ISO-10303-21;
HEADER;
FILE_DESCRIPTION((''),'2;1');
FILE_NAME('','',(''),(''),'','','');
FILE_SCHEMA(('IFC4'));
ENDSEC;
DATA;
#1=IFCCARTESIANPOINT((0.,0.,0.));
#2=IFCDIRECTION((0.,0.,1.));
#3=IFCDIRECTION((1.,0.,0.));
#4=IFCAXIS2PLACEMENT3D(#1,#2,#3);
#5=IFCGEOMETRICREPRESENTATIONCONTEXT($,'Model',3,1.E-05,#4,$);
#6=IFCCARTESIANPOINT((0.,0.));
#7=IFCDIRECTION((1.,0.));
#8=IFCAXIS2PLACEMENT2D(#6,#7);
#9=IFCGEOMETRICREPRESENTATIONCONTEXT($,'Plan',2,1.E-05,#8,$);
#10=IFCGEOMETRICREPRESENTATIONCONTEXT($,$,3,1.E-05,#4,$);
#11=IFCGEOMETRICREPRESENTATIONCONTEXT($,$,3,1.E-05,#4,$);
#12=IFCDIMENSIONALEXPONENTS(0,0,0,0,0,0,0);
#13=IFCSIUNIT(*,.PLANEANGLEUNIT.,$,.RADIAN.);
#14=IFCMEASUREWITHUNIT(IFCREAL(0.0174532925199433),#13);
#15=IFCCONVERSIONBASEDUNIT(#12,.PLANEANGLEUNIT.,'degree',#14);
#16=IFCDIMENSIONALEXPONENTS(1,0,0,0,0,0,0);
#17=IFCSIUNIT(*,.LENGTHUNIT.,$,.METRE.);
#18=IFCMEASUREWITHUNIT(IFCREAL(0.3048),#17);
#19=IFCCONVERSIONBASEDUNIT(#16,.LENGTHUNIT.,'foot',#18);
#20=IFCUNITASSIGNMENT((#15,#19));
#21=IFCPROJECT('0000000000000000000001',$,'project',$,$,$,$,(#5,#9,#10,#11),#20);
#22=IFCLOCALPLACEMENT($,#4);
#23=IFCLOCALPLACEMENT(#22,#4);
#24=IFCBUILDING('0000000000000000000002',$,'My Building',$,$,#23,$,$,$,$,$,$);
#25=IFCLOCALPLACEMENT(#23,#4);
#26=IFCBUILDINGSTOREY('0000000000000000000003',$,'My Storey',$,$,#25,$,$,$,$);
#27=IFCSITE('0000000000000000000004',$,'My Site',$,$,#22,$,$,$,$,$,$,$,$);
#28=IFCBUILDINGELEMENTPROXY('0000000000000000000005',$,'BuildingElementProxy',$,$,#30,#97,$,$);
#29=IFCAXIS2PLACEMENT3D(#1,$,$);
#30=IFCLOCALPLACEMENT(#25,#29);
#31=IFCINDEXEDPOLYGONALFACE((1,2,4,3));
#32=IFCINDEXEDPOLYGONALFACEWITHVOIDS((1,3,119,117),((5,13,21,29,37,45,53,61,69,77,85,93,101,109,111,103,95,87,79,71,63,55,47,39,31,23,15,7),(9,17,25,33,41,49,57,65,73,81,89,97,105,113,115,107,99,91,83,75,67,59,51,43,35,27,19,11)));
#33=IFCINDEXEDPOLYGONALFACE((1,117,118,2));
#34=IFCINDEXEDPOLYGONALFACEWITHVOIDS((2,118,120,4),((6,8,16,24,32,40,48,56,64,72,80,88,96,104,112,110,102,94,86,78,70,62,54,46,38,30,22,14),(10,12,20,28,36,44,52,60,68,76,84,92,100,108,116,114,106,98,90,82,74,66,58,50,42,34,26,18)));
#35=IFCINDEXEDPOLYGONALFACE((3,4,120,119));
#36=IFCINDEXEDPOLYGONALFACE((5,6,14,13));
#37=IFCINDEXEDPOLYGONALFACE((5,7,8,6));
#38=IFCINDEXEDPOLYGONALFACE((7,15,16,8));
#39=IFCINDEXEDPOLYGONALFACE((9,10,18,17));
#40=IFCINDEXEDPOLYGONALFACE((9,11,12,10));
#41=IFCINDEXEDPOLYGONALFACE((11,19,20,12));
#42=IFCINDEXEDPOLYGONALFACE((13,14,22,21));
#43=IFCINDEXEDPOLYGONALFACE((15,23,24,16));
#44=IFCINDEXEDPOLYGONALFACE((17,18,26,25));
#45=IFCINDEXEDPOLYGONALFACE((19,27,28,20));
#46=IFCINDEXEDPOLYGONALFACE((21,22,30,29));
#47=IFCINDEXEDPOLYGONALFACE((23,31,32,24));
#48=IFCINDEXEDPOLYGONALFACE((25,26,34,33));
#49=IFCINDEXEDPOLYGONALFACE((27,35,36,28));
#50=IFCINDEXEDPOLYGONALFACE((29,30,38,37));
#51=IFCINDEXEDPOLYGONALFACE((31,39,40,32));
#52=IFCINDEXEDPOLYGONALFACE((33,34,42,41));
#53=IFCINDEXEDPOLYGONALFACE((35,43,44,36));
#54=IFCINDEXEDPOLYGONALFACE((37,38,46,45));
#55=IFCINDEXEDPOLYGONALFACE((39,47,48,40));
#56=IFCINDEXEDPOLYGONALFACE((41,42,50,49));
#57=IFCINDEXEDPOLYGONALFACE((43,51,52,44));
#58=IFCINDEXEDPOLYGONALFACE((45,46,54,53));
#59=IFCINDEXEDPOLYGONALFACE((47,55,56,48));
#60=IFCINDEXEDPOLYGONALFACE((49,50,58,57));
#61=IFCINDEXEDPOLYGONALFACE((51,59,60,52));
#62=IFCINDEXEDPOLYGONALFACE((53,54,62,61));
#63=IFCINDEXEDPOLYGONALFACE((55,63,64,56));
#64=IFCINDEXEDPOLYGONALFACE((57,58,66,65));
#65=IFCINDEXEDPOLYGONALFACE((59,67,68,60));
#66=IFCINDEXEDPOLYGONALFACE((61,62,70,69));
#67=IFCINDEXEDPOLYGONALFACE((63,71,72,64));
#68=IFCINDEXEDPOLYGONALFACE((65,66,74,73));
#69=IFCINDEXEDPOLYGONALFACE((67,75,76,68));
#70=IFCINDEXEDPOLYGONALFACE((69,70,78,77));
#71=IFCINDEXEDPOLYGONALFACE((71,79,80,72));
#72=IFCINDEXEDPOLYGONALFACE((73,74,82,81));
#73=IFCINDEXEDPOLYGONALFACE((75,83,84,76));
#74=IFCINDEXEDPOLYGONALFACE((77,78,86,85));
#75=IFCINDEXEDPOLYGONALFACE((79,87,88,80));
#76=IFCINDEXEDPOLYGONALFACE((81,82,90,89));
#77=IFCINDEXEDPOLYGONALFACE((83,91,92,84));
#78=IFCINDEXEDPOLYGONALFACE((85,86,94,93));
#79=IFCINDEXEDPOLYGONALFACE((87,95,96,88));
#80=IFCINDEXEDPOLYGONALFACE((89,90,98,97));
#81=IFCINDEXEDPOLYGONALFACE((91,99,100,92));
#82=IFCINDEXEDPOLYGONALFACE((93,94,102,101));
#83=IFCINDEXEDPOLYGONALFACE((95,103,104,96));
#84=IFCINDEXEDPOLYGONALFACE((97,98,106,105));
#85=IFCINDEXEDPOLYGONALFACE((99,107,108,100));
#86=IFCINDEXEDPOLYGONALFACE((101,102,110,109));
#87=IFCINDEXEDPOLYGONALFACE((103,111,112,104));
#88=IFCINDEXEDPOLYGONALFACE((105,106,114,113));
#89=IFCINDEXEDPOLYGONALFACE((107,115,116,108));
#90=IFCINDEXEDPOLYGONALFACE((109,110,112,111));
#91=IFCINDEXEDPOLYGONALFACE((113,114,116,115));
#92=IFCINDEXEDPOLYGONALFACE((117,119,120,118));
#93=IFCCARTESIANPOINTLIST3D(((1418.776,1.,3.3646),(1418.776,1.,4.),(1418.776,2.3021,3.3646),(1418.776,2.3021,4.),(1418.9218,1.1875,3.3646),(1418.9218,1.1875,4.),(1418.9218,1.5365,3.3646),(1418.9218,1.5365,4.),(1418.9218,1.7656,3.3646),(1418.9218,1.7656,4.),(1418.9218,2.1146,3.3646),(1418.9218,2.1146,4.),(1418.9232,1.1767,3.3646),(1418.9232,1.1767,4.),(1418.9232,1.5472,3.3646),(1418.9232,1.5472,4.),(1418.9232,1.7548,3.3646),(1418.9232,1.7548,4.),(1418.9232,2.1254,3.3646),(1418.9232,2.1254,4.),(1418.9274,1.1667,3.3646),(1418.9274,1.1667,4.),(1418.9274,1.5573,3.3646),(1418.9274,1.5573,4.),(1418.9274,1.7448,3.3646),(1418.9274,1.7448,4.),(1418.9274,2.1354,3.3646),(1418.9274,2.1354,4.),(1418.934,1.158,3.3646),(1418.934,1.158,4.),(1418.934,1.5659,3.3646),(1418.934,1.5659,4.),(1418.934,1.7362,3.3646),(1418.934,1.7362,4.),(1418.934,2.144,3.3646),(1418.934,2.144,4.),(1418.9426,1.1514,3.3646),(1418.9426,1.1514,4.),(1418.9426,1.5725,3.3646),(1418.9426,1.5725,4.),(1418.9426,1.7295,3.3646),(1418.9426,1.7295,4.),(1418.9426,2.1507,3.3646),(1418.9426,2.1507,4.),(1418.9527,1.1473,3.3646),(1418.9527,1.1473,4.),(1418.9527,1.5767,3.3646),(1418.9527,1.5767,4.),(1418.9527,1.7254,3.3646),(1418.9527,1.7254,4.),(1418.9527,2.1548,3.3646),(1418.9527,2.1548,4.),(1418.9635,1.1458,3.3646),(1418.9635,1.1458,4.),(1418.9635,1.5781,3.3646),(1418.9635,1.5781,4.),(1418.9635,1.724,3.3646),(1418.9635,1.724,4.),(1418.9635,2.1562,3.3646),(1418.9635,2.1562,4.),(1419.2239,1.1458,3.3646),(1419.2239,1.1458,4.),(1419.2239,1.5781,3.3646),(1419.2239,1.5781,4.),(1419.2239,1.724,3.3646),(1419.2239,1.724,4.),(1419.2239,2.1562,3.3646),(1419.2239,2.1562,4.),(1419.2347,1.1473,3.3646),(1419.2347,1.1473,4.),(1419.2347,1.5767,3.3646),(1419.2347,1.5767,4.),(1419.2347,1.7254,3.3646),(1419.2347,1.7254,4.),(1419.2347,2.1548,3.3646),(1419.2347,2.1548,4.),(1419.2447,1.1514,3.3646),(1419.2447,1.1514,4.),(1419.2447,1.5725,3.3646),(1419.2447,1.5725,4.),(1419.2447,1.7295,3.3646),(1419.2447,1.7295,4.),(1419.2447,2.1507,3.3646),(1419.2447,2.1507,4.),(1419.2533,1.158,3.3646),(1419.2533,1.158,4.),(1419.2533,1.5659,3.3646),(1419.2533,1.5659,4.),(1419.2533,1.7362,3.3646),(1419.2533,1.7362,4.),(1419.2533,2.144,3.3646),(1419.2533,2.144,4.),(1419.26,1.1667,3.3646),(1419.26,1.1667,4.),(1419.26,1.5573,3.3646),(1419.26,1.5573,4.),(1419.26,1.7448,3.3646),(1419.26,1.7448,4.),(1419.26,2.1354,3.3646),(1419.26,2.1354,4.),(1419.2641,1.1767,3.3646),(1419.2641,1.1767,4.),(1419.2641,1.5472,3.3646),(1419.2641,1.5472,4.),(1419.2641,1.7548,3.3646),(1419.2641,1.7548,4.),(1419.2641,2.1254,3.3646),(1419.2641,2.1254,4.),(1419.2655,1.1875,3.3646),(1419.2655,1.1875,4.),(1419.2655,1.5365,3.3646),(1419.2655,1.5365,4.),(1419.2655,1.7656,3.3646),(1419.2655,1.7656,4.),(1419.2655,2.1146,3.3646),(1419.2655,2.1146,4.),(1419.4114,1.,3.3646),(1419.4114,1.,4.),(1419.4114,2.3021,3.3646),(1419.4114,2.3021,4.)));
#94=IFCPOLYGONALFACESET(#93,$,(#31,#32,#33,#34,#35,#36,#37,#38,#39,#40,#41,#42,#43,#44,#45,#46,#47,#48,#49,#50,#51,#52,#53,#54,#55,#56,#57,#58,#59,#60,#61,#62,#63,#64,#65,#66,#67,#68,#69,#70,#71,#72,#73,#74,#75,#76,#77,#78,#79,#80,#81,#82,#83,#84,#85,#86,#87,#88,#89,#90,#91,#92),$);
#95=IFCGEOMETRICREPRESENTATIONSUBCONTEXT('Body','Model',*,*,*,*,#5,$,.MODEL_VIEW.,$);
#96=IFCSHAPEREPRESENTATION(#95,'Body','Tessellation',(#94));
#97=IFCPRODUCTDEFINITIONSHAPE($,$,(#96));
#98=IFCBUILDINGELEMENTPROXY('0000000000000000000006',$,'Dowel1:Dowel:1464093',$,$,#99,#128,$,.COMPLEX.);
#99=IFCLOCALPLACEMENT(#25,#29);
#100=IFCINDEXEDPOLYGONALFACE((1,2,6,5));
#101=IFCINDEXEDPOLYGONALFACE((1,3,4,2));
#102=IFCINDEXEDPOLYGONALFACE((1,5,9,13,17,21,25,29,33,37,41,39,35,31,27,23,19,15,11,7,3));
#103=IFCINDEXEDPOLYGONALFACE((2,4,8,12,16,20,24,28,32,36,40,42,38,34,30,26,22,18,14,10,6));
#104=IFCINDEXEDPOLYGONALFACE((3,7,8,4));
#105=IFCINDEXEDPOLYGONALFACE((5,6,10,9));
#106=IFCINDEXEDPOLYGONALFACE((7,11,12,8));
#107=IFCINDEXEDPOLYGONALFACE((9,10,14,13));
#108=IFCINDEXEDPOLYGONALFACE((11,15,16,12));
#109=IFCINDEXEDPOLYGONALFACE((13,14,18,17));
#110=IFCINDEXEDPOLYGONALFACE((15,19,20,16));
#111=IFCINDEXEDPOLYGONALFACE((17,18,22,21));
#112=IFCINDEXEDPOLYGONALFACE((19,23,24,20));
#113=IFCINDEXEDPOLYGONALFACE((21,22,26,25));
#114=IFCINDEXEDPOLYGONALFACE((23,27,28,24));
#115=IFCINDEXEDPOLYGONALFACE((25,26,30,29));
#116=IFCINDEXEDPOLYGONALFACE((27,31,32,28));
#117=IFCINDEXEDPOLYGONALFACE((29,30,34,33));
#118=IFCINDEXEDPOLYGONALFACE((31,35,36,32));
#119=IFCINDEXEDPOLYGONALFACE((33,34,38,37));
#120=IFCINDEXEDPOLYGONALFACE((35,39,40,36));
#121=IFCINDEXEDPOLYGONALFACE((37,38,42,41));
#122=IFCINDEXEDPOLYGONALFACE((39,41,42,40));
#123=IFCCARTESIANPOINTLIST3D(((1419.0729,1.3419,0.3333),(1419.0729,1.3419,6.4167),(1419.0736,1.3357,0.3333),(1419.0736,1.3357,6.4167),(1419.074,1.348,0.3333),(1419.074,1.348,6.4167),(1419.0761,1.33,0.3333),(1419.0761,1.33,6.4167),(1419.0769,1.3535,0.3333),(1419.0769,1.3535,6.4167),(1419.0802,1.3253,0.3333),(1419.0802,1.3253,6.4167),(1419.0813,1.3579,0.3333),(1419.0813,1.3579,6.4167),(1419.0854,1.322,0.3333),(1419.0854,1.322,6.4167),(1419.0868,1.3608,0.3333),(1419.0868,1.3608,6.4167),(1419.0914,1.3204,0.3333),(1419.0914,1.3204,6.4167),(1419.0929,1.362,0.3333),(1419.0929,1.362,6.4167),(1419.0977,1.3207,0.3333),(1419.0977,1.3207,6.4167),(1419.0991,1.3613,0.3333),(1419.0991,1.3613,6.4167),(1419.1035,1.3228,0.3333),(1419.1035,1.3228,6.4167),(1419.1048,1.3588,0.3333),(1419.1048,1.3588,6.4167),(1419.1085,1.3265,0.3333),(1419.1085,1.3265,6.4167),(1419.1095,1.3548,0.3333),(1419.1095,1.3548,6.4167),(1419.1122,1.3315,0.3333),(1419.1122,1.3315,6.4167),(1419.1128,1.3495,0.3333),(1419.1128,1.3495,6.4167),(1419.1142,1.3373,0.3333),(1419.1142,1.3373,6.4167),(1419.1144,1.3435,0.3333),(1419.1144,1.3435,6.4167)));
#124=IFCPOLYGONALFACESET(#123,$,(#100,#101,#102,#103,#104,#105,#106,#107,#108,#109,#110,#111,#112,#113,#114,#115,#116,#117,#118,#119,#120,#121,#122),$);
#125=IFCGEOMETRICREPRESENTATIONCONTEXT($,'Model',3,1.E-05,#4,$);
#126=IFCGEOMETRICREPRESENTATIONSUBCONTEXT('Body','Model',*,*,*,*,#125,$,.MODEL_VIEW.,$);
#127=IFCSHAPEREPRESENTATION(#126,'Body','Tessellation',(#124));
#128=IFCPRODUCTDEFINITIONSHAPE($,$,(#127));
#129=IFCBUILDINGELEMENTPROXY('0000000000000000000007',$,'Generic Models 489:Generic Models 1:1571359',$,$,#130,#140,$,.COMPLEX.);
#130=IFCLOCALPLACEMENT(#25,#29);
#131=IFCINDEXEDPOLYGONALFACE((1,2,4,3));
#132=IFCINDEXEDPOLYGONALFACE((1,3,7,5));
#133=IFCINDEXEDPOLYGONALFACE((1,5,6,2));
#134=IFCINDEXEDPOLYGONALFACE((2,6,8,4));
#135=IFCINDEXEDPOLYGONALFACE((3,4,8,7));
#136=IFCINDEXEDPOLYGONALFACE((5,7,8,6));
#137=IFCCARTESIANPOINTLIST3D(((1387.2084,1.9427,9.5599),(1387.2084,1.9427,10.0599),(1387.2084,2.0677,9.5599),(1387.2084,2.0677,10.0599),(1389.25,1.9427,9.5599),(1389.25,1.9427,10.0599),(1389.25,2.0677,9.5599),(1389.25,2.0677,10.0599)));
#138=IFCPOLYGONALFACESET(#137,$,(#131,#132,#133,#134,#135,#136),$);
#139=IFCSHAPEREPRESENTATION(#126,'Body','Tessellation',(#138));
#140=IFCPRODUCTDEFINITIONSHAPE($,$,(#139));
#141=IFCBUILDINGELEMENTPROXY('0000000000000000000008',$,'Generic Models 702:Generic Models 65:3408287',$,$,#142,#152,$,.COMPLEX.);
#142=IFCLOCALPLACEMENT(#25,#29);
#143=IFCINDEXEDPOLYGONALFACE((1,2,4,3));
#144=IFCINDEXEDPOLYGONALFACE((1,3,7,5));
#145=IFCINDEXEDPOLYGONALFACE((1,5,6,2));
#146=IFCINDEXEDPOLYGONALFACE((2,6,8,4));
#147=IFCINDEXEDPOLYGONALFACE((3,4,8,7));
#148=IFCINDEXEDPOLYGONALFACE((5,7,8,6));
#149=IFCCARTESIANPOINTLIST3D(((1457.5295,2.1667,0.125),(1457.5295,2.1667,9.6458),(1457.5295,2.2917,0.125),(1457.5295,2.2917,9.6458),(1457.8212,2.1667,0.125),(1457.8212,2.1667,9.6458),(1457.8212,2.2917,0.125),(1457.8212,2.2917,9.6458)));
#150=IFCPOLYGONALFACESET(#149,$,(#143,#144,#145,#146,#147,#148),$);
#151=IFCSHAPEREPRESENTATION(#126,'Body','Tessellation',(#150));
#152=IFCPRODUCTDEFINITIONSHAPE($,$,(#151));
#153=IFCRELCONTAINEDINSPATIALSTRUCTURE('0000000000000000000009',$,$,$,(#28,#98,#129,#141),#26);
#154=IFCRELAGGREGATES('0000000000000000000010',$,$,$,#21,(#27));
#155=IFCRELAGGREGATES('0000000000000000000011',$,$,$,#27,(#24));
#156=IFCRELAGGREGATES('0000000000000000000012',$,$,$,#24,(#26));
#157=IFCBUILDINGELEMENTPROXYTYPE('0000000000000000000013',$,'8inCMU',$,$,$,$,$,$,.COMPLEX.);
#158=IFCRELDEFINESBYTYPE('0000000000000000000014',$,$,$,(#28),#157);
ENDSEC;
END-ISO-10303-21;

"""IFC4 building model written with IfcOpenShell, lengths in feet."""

from ifc_helpers import new_model, entity, si_unit, converted_unit, frame, origin_with_axes, origin_2d_with_axis, place, context, subcontext, project, spatial, polyline, line, indexed_curve, circle, outline, extrude, source, transform, mapped, type_object, type_shapes, element, save


model = new_model("IFC4")

# Units and contexts
model_context_1 = context("Model", 3, precision=1e-05, world=origin_with_axes())
plan_context = context("Plan", 2, precision=1e-05, world=origin_2d_with_axis())
model_context_2 = context("Model", 3, precision=1e-05, world=origin_with_axes())
context_of_model_1 = context(None, 3, precision=1e-05, world=origin_with_axes())
context_of_model_2 = context(None, 3, precision=1e-05, world=origin_with_axes())
body_context_1 = subcontext(model_context_1, "Body", "Model", "MODEL_VIEW")
body_context_2 = subcontext(model_context_2, "Body", "Model", "MODEL_VIEW")
ifc_project = project(units=[converted_unit("PLANEANGLEUNIT", "degree", entity("IfcReal", 0.0174532925199433), si_unit("PLANEANGLEUNIT", "RADIAN"), dimensions=[0, 0, 0, 0, 0, 0, 0]), converted_unit("LENGTHUNIT", "foot", entity("IfcReal", 0.3048), si_unit("LENGTHUNIT", "METRE"), dimensions=[1, 0, 0, 0, 0, 0, 0])], contexts=[model_context_1, plan_context, context_of_model_1, context_of_model_2])

# Site, building, storey
site_placement = place(None, origin_with_axes())
site = spatial("IfcSite", under=ifc_project, at=site_placement, Name="My Site")
building_placement = place(site_placement, origin_with_axes())
building = spatial("IfcBuilding", under=site, at=building_placement, Name="My Building")
storey_placement = place(building_placement, origin_with_axes())
storey = spatial("IfcBuildingStorey", under=building, at=storey_placement, Name="My Storey")

# Building element proxies
building_element_proxy_type_1 = type_object("IfcBuildingElementProxyType", Name="8inCMU", PredefinedType="COMPLEX")
shared_shape_1 = source(origin_with_axes(), body_context_1, "Body", "SweptSolid", [
    extrude(outline(indexed_curve([(-0.3177, -0.651), (0.3177, -0.651), (0.3177, 0.651), (-0.3177, 0.651), (0.1719, -0.1146), (0.1719, -0.4635), (0.1705, -0.4743), (0.1663, -0.4844), (0.1597, -0.493), (0.151, -0.4996), (0.141, -0.5038), (0.1302, -0.5052), (-0.1302, -0.5052), (-0.141, -0.5038), (-0.151, -0.4996), (-0.1597, -0.493), (-0.1663, -0.4844), (-0.1705, -0.4743), (-0.1719, -0.4635), (-0.1719, -0.1146), (-0.1705, -0.1038), (-0.1663, -0.0938), (-0.1597, -0.0851), (-0.151, -0.0785), (-0.141, -0.0743), (-0.1302, -0.0729), (0.1302, -0.0729), (0.141, -0.0743), (0.151, -0.0785), (0.1597, -0.0851), (0.1663, -0.0938), (0.1705, -0.1038), (0.151, 0.0785), (0.141, 0.0743), (0.1302, 0.0729), (-0.1302, 0.0729), (-0.141, 0.0743), (-0.151, 0.0785), (-0.1597, 0.0851), (-0.1663, 0.0937), (-0.1705, 0.1038), (-0.1719, 0.1146), (-0.1719, 0.4635), (-0.1705, 0.4743), (-0.1663, 0.4844), (-0.1597, 0.493), (-0.151, 0.4996), (-0.141, 0.5038), (-0.1302, 0.5052), (0.1302, 0.5052), (0.141, 0.5038), (0.151, 0.4996), (0.1597, 0.493), (0.1663, 0.4844), (0.1705, 0.4743), (0.1719, 0.4635), (0.1719, 0.1146), (0.1705, 0.1038), (0.1663, 0.0937), (0.1597, 0.0851)], segments=[line(4, 3), line(3, 2), line(2, 1), line(1, 4)], self_intersect=False), holes=[indexed_curve([(-0.3177, -0.651), (0.3177, -0.651), (0.3177, 0.651), (-0.3177, 0.651), (0.1719, -0.1146), (0.1719, -0.4635), (0.1705, -0.4743), (0.1663, -0.4844), (0.1597, -0.493), (0.151, -0.4996), (0.141, -0.5038), (0.1302, -0.5052), (-0.1302, -0.5052), (-0.141, -0.5038), (-0.151, -0.4996), (-0.1597, -0.493), (-0.1663, -0.4844), (-0.1705, -0.4743), (-0.1719, -0.4635), (-0.1719, -0.1146), (-0.1705, -0.1038), (-0.1663, -0.0938), (-0.1597, -0.0851), (-0.151, -0.0785), (-0.141, -0.0743), (-0.1302, -0.0729), (0.1302, -0.0729), (0.141, -0.0743), (0.151, -0.0785), (0.1597, -0.0851), (0.1663, -0.0938), (0.1705, -0.1038), (0.151, 0.0785), (0.141, 0.0743), (0.1302, 0.0729), (-0.1302, 0.0729), (-0.141, 0.0743), (-0.151, 0.0785), (-0.1597, 0.0851), (-0.1663, 0.0937), (-0.1705, 0.1038), (-0.1719, 0.1146), (-0.1719, 0.4635), (-0.1705, 0.4743), (-0.1663, 0.4844), (-0.1597, 0.493), (-0.151, 0.4996), (-0.141, 0.5038), (-0.1302, 0.5052), (0.1302, 0.5052), (0.141, 0.5038), (0.151, 0.4996), (0.1597, 0.493), (0.1663, 0.4844), (0.1705, 0.4743), (0.1719, 0.4635), (0.1719, 0.1146), (0.1705, 0.1038), (0.1663, 0.0937), (0.1597, 0.0851)], segments=[line(20, 19), line(19, 18), line(18, 17), line(17, 16), line(16, 15), line(15, 14), line(14, 13), line(13, 12), line(12, 11), line(11, 10), line(10, 9), line(9, 8), line(8, 7), line(7, 6), line(6, 5), line(5, 32), line(32, 31), line(31, 30), line(30, 29), line(29, 28), line(28, 27), line(27, 26), line(26, 25), line(25, 24), line(24, 23), line(23, 22), line(22, 21), line(21, 20)], self_intersect=False), indexed_curve([(-0.3177, -0.651), (0.3177, -0.651), (0.3177, 0.651), (-0.3177, 0.651), (0.1719, -0.1146), (0.1719, -0.4635), (0.1705, -0.4743), (0.1663, -0.4844), (0.1597, -0.493), (0.151, -0.4996), (0.141, -0.5038), (0.1302, -0.5052), (-0.1302, -0.5052), (-0.141, -0.5038), (-0.151, -0.4996), (-0.1597, -0.493), (-0.1663, -0.4844), (-0.1705, -0.4743), (-0.1719, -0.4635), (-0.1719, -0.1146), (-0.1705, -0.1038), (-0.1663, -0.0938), (-0.1597, -0.0851), (-0.151, -0.0785), (-0.141, -0.0743), (-0.1302, -0.0729), (0.1302, -0.0729), (0.141, -0.0743), (0.151, -0.0785), (0.1597, -0.0851), (0.1663, -0.0938), (0.1705, -0.1038), (0.151, 0.0785), (0.141, 0.0743), (0.1302, 0.0729), (-0.1302, 0.0729), (-0.141, 0.0743), (-0.151, 0.0785), (-0.1597, 0.0851), (-0.1663, 0.0937), (-0.1705, 0.1038), (-0.1719, 0.1146), (-0.1719, 0.4635), (-0.1705, 0.4743), (-0.1663, 0.4844), (-0.1597, 0.493), (-0.151, 0.4996), (-0.141, 0.5038), (-0.1302, 0.5052), (0.1302, 0.5052), (0.141, 0.5038), (0.151, 0.4996), (0.1597, 0.493), (0.1663, 0.4844), (0.1705, 0.4743), (0.1719, 0.4635), (0.1719, 0.1146), (0.1705, 0.1038), (0.1663, 0.0937), (0.1597, 0.0851)], segments=[line(44, 43), line(43, 42), line(42, 41), line(41, 40), line(40, 39), line(39, 38), line(38, 37), line(37, 36), line(36, 35), line(35, 34), line(34, 33), line(33, 60), line(60, 59), line(59, 58), line(58, 57), line(57, 56), line(56, 55), line(55, 54), line(54, 53), line(53, 52), line(52, 51), line(51, 50), line(50, 49), line(49, 48), line(48, 47), line(47, 46), line(46, 45), line(45, 44)], self_intersect=False)]), frame((-0.651, 0.0, 0.0), z_axis=(0.0, 0.0, 1.0), x_axis=(0.0, -1.0, 0.0)), (0.0, 0.0, 1.0), 0.6354),
])
type_shapes(building_element_proxy_type_1, [shared_shape_1])
for number, where, z_axis, x_axis, name in (
    (1, (1419.0936, 2.3021, 3.3646), (0.0, 0.0, 1.0), (0.0, 1.0, 0.0), "BuildingElementProxy"),
):
    element("IfcBuildingElementProxy", number, at=place(storey_placement, frame(where, z_axis=z_axis, x_axis=x_axis)), inside=storey, type_object=building_element_proxy_type_1, Name=name, context=body_context_1, shape_type="MappedRepresentation", body=[
        mapped(shared_shape_1, transform((0.0, 0.0, 0.0), x_axis=(1.0, 0.0, 0.0), y_axis=(0.0, 1.0, 0.0), z_axis=(0.0, 0.0, 1.0), scale=1.0)),
    ])
proxy_1_placement = place(storey_placement, frame((1419.0729, 1.3203, 0.3333), z_axis=(0.0, 0.0, 1.0), x_axis=(0.0, 1.0, 0.0)))
element("IfcBuildingElementProxy", 2, at=proxy_1_placement, inside=storey, Name="Dowel1:Dowel:1464093", PredefinedType="COMPLEX", context=body_context_2, shape_type="SweptSolid", body=[
    extrude(circle(Radius=0.0208, at=origin_2d_with_axis()), frame((0.0208, -0.0208, 0.0), z_axis=(0.0, 0.0, -1.0), x_axis=(-0.464723, -0.885456, 0.0)), (0.0, 0.0, -1.0), 6.0833),
])
proxy_2_placement = place(storey_placement, frame((1387.2084, 1.9427, 9.5599), z_axis=(1.0, 0.0, 0.0), x_axis=(0.0, 0.0, -1.0)))
element("IfcBuildingElementProxy", 3, at=proxy_2_placement, inside=storey, Name="Generic Models 489:Generic Models 1:1571359", PredefinedType="COMPLEX", context=body_context_2, shape_type="SweptSolid", body=[
    extrude(outline(polyline([(-0.0625, -0.25), (0.0625, -0.25), (0.0625, 0.25), (-0.0625, 0.25), (-0.0625, -0.25)])), frame((-0.25, 0.0625, 0.0), z_axis=(0.0, 0.0, -1.0), x_axis=(0.0, -1.0, 0.0)), (0.0, 0.0, -1.0), 2.0417),
])
proxy_3_placement = place(storey_placement, frame((1457.5295, 2.1667, 0.125), z_axis=(0.0, 0.0, 1.0), x_axis=(1.0, 0.0, 0.0)))
element("IfcBuildingElementProxy", 4, at=proxy_3_placement, inside=storey, Name="Generic Models 702:Generic Models 65:3408287", PredefinedType="COMPLEX", context=body_context_2, shape_type="SweptSolid", body=[
    extrude(outline(polyline([(-0.1458, -0.0625), (0.1458, -0.0625), (0.1458, 0.0625), (-0.1458, 0.0625), (-0.1458, -0.0625)])), frame((0.1458, 0.0625, 0.0), z_axis=(0.0, 0.0, -1.0), x_axis=(-1.0, 0.0, 0.0)), (0.0, 0.0, -1.0), 9.5208),
])

save(model, "model.ifc")
